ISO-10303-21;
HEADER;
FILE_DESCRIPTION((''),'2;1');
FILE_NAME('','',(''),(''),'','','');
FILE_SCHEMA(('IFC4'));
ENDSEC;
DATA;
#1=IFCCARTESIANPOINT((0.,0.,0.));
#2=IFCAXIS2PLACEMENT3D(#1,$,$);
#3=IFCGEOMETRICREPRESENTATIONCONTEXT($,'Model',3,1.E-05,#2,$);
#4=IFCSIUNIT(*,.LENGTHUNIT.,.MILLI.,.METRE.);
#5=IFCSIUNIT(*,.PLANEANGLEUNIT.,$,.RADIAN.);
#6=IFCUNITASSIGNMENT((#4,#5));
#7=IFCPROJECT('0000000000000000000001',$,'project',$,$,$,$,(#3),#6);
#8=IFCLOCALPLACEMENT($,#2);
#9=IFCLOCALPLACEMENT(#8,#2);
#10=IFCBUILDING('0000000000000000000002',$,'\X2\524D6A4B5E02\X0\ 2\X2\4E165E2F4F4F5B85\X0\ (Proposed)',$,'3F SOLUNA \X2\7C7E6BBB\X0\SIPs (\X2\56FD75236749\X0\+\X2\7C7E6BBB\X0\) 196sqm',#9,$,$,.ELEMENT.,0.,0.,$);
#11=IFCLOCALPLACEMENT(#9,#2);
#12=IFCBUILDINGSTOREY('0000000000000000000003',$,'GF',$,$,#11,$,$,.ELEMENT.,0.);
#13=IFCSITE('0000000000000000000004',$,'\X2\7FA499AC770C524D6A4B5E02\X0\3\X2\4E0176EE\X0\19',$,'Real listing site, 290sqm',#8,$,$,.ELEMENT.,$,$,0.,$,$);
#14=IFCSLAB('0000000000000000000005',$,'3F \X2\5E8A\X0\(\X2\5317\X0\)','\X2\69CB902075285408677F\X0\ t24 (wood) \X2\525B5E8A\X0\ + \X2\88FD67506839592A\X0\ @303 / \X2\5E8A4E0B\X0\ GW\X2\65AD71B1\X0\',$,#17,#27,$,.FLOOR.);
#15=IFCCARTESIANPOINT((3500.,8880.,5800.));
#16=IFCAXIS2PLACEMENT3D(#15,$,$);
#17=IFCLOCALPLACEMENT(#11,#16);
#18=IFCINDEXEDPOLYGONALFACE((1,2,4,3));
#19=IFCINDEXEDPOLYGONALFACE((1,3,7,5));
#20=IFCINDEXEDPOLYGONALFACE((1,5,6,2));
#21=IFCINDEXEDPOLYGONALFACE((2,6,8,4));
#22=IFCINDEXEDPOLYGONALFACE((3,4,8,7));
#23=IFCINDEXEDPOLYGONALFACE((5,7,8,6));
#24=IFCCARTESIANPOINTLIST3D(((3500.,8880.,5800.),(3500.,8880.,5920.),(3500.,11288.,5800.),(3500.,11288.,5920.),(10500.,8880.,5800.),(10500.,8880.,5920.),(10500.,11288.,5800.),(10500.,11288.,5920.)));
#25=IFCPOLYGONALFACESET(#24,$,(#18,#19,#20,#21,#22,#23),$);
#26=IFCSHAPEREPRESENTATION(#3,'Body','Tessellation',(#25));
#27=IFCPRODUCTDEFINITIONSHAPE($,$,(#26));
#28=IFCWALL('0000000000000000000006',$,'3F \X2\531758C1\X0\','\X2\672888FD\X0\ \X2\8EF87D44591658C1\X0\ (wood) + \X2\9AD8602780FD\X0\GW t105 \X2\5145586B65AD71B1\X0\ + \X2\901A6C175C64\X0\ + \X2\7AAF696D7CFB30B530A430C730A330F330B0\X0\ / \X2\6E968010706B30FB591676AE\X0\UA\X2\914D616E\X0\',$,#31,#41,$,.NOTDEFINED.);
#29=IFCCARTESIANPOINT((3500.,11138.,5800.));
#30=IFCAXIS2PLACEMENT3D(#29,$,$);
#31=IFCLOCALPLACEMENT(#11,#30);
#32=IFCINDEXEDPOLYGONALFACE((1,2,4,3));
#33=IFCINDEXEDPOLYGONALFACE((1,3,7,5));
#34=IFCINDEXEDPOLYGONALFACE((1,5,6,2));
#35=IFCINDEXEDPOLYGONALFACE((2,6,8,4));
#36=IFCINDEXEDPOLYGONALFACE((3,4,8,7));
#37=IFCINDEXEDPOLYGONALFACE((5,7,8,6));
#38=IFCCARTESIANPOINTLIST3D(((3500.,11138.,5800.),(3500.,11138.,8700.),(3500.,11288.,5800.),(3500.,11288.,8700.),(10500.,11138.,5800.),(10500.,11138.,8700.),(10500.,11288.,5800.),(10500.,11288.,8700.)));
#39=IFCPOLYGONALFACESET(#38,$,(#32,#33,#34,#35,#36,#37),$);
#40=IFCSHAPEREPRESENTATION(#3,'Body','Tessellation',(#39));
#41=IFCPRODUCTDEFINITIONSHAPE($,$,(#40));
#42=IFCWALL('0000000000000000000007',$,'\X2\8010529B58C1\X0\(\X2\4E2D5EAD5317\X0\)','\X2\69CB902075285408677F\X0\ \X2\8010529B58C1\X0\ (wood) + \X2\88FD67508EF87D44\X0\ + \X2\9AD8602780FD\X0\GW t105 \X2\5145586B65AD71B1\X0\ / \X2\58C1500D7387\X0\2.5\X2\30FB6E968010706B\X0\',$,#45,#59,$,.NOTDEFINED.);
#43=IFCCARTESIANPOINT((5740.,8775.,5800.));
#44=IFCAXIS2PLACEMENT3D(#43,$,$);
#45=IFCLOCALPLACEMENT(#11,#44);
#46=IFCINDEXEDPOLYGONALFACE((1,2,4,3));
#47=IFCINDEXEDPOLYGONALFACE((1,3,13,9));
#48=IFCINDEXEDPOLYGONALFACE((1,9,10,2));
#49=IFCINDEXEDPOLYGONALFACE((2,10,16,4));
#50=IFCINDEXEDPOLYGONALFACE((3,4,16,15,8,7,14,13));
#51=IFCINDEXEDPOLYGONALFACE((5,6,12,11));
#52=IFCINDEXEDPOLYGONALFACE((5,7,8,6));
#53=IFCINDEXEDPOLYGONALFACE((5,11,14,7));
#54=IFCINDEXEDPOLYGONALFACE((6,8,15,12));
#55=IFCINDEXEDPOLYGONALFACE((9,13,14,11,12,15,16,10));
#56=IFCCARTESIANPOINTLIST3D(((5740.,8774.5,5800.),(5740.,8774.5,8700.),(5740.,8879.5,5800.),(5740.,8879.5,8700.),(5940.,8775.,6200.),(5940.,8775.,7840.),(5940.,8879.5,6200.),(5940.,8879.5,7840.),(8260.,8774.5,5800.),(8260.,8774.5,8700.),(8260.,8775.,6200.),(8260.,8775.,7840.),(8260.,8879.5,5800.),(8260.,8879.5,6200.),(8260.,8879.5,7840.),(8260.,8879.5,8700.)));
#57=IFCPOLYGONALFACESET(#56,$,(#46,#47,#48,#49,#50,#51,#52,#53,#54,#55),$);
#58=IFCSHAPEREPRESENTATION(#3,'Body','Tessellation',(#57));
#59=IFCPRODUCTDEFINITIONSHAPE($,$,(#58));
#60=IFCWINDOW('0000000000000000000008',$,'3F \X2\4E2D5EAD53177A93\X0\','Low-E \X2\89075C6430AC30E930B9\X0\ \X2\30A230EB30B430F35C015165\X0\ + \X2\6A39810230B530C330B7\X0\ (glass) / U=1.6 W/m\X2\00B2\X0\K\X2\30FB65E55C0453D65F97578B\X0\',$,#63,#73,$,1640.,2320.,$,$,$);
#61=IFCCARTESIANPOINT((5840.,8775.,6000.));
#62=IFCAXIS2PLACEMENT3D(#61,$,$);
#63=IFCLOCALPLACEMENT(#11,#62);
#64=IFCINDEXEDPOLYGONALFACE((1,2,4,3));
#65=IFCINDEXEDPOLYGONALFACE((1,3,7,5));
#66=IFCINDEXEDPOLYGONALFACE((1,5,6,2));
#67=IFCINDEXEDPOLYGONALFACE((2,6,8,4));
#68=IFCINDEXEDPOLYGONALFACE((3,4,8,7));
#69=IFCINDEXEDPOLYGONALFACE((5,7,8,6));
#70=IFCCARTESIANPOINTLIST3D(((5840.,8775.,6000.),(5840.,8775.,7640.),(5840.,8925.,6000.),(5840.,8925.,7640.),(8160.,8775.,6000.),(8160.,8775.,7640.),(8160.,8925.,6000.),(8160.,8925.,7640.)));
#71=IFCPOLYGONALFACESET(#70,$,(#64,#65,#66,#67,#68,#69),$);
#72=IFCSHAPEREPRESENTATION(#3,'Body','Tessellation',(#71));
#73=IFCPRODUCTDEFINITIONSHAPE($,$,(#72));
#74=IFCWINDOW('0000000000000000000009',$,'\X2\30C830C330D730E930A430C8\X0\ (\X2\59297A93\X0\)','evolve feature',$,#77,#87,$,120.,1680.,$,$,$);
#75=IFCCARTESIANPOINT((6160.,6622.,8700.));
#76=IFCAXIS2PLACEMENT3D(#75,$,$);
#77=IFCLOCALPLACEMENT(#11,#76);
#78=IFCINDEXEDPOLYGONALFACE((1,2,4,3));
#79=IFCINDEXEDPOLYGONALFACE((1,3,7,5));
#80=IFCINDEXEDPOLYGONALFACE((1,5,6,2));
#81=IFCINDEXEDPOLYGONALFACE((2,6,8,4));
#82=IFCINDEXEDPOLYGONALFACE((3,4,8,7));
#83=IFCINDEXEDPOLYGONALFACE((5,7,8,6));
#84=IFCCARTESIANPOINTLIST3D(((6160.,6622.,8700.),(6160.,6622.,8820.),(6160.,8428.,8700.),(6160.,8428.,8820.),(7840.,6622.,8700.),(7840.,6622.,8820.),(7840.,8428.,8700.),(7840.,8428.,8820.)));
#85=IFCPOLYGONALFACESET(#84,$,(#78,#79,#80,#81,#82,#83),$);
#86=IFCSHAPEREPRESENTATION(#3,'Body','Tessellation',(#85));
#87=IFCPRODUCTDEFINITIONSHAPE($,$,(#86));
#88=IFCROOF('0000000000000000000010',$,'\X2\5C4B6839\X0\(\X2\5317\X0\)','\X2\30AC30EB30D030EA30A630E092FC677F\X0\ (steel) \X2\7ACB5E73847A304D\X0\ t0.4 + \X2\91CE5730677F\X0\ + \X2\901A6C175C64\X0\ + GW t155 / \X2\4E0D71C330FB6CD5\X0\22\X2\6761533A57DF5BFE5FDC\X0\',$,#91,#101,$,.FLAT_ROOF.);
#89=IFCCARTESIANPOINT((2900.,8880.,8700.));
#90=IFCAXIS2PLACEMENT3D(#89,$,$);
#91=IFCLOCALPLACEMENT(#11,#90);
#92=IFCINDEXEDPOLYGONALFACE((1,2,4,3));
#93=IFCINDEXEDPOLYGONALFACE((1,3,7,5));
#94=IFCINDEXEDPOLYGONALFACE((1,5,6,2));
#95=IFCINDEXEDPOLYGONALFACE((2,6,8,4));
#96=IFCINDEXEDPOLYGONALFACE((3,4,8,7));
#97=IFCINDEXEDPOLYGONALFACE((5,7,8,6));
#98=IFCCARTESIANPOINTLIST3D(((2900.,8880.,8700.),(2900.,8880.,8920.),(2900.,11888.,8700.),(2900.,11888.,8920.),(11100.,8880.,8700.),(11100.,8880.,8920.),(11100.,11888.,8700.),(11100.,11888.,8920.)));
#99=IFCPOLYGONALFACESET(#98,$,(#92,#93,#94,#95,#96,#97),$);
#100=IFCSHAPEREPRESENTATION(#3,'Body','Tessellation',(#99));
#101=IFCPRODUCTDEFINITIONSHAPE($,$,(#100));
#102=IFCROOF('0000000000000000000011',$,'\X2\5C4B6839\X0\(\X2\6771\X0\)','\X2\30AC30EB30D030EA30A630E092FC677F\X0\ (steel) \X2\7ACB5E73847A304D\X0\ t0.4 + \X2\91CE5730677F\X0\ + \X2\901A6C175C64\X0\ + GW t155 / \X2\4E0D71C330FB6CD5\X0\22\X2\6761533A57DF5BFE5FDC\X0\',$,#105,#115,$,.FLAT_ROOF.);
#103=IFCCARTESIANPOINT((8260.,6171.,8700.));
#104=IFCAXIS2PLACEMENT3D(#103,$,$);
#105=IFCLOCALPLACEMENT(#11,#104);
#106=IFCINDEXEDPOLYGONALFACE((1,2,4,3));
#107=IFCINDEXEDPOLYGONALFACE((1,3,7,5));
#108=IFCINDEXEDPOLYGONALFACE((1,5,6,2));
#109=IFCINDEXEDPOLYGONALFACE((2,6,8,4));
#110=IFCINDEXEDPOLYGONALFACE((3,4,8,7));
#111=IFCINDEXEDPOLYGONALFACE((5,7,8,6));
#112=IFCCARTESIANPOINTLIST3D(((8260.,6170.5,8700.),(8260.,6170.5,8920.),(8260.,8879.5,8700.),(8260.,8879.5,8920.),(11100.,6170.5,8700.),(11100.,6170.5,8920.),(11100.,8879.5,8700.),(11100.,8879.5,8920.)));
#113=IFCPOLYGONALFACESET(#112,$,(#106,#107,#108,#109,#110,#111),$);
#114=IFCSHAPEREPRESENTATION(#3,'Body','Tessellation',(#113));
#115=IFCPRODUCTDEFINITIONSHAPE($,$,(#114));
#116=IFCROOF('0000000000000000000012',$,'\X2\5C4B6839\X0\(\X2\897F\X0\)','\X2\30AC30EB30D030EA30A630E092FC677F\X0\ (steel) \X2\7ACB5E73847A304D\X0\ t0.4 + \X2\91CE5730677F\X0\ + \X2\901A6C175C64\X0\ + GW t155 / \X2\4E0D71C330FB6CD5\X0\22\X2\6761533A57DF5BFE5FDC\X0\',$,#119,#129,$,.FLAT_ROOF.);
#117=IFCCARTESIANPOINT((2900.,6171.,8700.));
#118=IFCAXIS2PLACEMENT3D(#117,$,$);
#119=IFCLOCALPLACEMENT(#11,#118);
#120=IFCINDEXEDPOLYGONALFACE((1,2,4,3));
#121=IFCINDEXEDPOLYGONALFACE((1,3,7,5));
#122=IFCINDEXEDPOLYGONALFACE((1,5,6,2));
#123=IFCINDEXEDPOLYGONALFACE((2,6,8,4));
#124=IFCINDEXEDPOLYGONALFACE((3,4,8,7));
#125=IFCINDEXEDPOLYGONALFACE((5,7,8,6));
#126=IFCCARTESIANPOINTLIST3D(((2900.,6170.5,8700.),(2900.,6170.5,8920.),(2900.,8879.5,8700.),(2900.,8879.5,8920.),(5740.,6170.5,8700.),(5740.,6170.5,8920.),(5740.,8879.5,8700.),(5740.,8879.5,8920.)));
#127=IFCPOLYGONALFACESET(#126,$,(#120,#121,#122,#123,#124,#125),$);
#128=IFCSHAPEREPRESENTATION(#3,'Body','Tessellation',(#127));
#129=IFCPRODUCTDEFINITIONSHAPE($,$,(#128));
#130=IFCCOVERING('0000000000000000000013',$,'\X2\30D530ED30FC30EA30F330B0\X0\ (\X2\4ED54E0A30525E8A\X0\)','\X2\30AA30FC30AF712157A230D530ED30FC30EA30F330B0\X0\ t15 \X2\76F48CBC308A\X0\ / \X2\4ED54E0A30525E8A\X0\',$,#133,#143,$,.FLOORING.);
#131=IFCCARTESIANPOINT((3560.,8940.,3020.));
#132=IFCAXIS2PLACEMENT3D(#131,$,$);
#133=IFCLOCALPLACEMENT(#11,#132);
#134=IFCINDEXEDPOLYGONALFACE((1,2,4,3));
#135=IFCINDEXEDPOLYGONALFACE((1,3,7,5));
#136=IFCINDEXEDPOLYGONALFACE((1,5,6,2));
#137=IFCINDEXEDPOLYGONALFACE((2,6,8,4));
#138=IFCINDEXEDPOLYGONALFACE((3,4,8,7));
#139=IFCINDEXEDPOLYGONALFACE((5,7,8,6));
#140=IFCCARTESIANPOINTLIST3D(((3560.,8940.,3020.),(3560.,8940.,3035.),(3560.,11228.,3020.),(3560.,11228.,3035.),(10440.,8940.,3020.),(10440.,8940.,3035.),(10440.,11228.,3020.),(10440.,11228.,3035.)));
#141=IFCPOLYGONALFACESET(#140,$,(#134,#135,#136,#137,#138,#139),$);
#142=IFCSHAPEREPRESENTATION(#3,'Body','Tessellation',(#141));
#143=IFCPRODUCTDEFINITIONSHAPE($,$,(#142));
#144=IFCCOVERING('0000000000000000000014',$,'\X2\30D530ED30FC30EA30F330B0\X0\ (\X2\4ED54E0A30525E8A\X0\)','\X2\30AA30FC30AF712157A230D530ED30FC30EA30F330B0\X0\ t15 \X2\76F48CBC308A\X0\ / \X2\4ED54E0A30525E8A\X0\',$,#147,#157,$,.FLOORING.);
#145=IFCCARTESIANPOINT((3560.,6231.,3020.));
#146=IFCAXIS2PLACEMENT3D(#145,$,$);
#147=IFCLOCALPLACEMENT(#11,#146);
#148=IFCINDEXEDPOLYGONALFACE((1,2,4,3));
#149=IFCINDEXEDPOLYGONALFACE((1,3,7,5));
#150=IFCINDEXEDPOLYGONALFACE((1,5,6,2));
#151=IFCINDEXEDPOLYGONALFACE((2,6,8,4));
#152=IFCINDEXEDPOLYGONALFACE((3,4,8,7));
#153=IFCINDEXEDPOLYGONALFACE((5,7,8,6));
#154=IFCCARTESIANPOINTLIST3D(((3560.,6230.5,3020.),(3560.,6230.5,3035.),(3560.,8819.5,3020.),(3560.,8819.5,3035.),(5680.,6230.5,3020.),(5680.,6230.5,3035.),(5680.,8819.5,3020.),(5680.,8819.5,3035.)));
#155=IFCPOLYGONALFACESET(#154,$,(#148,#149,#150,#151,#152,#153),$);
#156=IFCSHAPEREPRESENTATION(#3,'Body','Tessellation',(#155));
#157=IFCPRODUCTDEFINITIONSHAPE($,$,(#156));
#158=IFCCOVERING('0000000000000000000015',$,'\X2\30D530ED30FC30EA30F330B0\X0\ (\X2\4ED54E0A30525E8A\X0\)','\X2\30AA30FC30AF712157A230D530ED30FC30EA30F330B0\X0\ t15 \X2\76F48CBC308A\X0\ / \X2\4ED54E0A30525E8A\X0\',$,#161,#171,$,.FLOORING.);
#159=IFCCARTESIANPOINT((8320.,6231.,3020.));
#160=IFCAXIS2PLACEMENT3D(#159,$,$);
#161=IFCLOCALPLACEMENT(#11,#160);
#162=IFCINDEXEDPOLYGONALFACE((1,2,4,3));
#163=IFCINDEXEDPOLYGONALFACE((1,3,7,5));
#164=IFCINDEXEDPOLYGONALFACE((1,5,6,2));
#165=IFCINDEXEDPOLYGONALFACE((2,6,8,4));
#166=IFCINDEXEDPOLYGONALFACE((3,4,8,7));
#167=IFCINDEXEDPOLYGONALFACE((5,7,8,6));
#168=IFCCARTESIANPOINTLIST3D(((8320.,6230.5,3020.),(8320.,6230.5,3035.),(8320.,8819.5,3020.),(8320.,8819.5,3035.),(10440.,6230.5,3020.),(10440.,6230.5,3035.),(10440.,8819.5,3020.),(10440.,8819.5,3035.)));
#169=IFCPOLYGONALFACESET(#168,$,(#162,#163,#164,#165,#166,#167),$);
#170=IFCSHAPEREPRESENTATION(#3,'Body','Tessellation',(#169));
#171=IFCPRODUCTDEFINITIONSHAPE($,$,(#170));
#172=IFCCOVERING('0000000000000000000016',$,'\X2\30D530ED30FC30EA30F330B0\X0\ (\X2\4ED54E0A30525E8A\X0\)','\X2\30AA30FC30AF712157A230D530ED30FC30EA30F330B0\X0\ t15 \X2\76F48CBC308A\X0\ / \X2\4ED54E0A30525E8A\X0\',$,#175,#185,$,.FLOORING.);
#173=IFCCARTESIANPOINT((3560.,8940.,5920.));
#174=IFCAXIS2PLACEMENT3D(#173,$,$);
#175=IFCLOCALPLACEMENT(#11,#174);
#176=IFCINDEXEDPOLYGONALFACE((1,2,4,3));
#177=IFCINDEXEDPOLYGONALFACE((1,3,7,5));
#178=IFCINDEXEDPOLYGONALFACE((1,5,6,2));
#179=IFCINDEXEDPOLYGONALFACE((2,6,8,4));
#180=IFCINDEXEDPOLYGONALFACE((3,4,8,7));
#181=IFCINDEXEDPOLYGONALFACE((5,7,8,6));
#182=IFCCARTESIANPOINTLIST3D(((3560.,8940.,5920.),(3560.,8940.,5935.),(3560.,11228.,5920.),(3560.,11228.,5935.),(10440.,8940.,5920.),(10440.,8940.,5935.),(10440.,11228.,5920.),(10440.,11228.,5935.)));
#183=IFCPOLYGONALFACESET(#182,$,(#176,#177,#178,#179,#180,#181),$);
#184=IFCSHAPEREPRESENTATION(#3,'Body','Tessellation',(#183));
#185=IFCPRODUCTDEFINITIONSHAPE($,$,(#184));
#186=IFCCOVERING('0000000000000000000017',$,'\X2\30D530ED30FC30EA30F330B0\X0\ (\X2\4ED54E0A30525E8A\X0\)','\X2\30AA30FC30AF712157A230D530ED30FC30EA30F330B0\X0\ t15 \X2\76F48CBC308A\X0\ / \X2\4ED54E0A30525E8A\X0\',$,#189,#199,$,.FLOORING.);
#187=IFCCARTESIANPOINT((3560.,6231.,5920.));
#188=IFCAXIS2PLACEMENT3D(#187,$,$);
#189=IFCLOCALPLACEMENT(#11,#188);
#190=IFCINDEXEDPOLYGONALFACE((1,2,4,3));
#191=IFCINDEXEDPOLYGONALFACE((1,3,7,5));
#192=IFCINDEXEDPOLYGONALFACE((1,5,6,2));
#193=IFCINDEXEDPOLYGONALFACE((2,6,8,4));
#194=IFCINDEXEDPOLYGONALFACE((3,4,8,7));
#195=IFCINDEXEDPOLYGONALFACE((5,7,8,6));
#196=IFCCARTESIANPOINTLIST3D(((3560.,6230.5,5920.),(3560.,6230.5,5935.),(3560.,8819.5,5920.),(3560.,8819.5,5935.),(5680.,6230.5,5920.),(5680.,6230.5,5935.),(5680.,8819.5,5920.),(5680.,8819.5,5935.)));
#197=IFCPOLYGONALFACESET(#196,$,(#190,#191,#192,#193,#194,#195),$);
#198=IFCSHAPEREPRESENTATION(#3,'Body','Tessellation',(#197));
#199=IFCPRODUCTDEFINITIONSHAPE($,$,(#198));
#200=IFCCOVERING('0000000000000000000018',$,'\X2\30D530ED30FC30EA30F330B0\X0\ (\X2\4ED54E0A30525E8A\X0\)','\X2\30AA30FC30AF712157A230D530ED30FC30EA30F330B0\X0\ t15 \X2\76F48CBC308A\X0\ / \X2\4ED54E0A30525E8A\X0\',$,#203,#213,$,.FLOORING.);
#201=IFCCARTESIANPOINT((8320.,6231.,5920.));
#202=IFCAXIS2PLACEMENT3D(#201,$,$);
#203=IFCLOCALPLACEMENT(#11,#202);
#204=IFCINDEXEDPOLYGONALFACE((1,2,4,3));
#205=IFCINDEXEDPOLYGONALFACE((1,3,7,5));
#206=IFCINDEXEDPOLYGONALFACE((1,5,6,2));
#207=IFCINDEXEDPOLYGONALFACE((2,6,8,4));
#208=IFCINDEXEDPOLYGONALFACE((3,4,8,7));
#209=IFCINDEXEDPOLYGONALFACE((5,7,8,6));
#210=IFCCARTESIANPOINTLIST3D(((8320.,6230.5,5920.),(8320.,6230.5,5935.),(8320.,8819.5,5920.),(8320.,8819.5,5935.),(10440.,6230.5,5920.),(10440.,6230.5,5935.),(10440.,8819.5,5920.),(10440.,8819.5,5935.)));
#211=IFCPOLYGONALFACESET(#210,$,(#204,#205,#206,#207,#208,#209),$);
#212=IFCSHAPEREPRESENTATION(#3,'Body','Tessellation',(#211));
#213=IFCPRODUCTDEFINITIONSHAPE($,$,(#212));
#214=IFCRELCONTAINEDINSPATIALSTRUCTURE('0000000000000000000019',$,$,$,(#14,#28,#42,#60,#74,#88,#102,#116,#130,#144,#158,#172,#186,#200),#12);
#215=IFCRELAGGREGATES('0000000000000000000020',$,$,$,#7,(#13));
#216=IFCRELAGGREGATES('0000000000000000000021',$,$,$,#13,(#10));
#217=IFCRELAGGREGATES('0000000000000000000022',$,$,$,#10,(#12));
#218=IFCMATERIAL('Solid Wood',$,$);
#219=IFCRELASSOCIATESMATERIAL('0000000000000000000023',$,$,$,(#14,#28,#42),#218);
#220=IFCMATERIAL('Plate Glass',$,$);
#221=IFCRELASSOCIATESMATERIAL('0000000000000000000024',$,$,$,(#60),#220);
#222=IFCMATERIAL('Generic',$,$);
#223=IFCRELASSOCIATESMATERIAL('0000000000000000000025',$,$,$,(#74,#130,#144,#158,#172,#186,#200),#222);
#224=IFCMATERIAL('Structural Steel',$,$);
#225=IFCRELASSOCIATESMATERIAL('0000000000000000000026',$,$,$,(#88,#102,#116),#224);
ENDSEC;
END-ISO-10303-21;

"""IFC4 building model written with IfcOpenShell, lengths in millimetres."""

from ifc_helpers import new_model, si_unit, frame, frame_2d, origin, place, context, project, spatial, rectangle, extrude, material, element, fill, save


model = new_model("IFC4")

# Units and contexts
model_context = context("Model", 3, precision=1e-05, world=origin())
ifc_project = project(units=[si_unit("LENGTHUNIT", "METRE", prefix="MILLI"), si_unit("PLANEANGLEUNIT", "RADIAN")], contexts=[model_context])

# Site, building, storey
site_placement = place(None, origin())
site = spatial("IfcSite", under=ifc_project, at=site_placement, Name="群馬県前橋市3丁目19", ObjectType="Real listing site, 290sqm", CompositionType="ELEMENT", RefElevation=0.0)
building_placement = place(site_placement, origin())
building = spatial("IfcBuilding", under=site, at=building_placement, Name="前橋市 2世帯住宅 (Proposed)", ObjectType="3F SOLUNA 籾殻SIPs (国産杉+籾殻) 196sqm", CompositionType="ELEMENT", ElevationOfRefHeight=0.0, ElevationOfTerrain=0.0)
storey_placement = place(building_placement, origin())
storey = spatial("IfcBuildingStorey", under=building, at=storey_placement, Name="GF", CompositionType="ELEMENT", Elevation=0.0)

# Slab
ifc_material_1 = material(Name="Solid Wood")
slab_placement = place(storey_placement, frame((3500.0, 8880.0, 5800.0)))
element("IfcSlab", 1, at=slab_placement, inside=storey, material=ifc_material_1, Name="3F 床(北)", Description="構造用合板 t24 (wood) 剛床 + 製材根太 @303 / 床下 GW断熱", PredefinedType="FLOOR", context=model_context, shape_type="SweptSolid", body=[
    extrude(rectangle(XDim=7000.0, YDim=2408.0, at=frame_2d((3500.0, 1204.0))), frame((3500.0, 8880.0, 5800.0)), (0.0, 0.0, 1.0), 120.0),
])

# Wall
wall_1_placement = place(storey_placement, frame((3500.0, 11138.0, 5800.0)))
element("IfcWall", 2, at=wall_1_placement, inside=storey, material=ifc_material_1, Name="3F 北壁", Description="木製 軸組外壁 (wood) + 高性能GW t105 充填断熱 + 通気層 + 窯業系サイディング / 準耐火・外皮UA配慮", PredefinedType="NOTDEFINED", context=model_context, shape_type="SweptSolid", body=[
    extrude(rectangle(XDim=7000.0, YDim=150.0, at=frame_2d((3500.0, 75.0))), frame((3500.0, 11138.0, 5800.0)), (0.0, 0.0, 1.0), 2900.0),
])

# Wall, opening, window
wall_2_placement = place(storey_placement, frame((5740.0, 8775.0, 5800.0)))
wall_2 = element("IfcWall", 3, at=wall_2_placement, inside=storey, material=ifc_material_1, Name="耐力壁(中庭北)", Description="構造用合板 耐力壁 (wood) + 製材軸組 + 高性能GW t105 充填断熱 / 壁倍率2.5・準耐火", PredefinedType="NOTDEFINED", context=model_context, shape_type="SweptSolid", body=[
    extrude(rectangle(XDim=2520.0, YDim=105.0, at=frame_2d((1260.0, 52.0))), frame((5740.0, 8775.0, 5800.0)), (0.0, 0.0, 1.0), 2900.0),
])
opening_placement = place(storey_placement, frame((5840.0, 8775.0, 6000.0)))
opening = element("IfcOpeningElement", 4, at=opening_placement, cuts=wall_2, PredefinedType="NOTDEFINED", context=model_context, shape_type="SweptSolid", body=[
    extrude(rectangle(XDim=2320.0, YDim=150.0, at=frame_2d((1160.0, 75.0))), frame((5840.0, 8775.0, 6000.0)), (0.0, 0.0, 1.0), 1640.0),
])
ifc_material_2 = material(Name="Plate Glass")
window_1_placement = place(storey_placement, frame((5840.0, 8775.0, 6000.0)))
window_1 = element("IfcWindow", 5, at=window_1_placement, inside=storey, material=ifc_material_2, Name="3F 中庭北窓", Description="Low-E 複層ガラス アルゴン封入 + 樹脂サッシ (glass) / U=1.6 W/m²K・日射取得型", OverallHeight=1640.0, OverallWidth=2320.0, context=model_context, shape_type="SweptSolid", body=[
    extrude(rectangle(XDim=2320.0, YDim=150.0, at=frame_2d((1160.0, 75.0))), frame((5840.0, 8775.0, 6000.0)), (0.0, 0.0, 1.0), 1640.0),
])
fill(opening, window_1)

# Window
ifc_material_3 = material(Name="Generic")
window_2_placement = place(storey_placement, frame((6160.0, 6622.0, 8700.0)))
element("IfcWindow", 6, at=window_2_placement, inside=storey, material=ifc_material_3, Name="トップライト (天窓)", Description="evolve feature", OverallHeight=120.0, OverallWidth=1680.0, context=model_context, shape_type="SweptSolid", body=[
    extrude(rectangle(XDim=1680.0, YDim=1806.0, at=frame_2d((840.0, 903.0))), frame((6160.0, 6622.0, 8700.0)), (0.0, 0.0, 1.0), 120.0),
])

# Roofs
ifc_material_4 = material(Name="Structural Steel")
roof_1_placement = place(storey_placement, frame((2900.0, 8880.0, 8700.0)))
element("IfcRoof", 7, at=roof_1_placement, inside=storey, material=ifc_material_4, Name="屋根(北)", Description="ガルバリウム鋼板 (steel) 立平葺き t0.4 + 野地板 + 通気層 + GW t155 / 不燃・法22条区域対応", PredefinedType="FLAT_ROOF", context=model_context, shape_type="SweptSolid", body=[
    extrude(rectangle(XDim=8200.0, YDim=3008.0, at=frame_2d((4100.0, 1504.0))), frame((2900.0, 8880.0, 8700.0)), (0.0, 0.0, 1.0), 220.0),
])
roof_2_placement = place(storey_placement, frame((8260.0, 6171.0, 8700.0)))
element("IfcRoof", 8, at=roof_2_placement, inside=storey, material=ifc_material_4, Name="屋根(東)", Description="ガルバリウム鋼板 (steel) 立平葺き t0.4 + 野地板 + 通気層 + GW t155 / 不燃・法22条区域対応", PredefinedType="FLAT_ROOF", context=model_context, shape_type="SweptSolid", body=[
    extrude(rectangle(XDim=2840.0, YDim=2709.0, at=frame_2d((1420.0, 1354.0))), frame((8260.0, 6171.0, 8700.0)), (0.0, 0.0, 1.0), 220.0),
])
roof_3_placement = place(storey_placement, frame((2900.0, 6171.0, 8700.0)))
element("IfcRoof", 9, at=roof_3_placement, inside=storey, material=ifc_material_4, Name="屋根(西)", Description="ガルバリウム鋼板 (steel) 立平葺き t0.4 + 野地板 + 通気層 + GW t155 / 不燃・法22条区域対応", PredefinedType="FLAT_ROOF", context=model_context, shape_type="SweptSolid", body=[
    extrude(rectangle(XDim=2840.0, YDim=2709.0, at=frame_2d((1420.0, 1354.0))), frame((2900.0, 6171.0, 8700.0)), (0.0, 0.0, 1.0), 220.0),
])

# Coverings
covering_1_placement = place(storey_placement, frame((3560.0, 8940.0, 3020.0)))
element("IfcCovering", 10, at=covering_1_placement, inside=storey, material=ifc_material_3, Name="フローリング (仕上げ床)", Description="オーク無垢フローリング t15 直貼り / 仕上げ床", PredefinedType="FLOORING", context=model_context, shape_type="SweptSolid", body=[
    extrude(rectangle(XDim=6880.0, YDim=2288.0, at=frame_2d((3440.0, 1144.0))), frame((3560.0, 8940.0, 3020.0)), (0.0, 0.0, 1.0), 15.0),
])
covering_2_placement = place(storey_placement, frame((3560.0, 6231.0, 3020.0)))
element("IfcCovering", 11, at=covering_2_placement, inside=storey, material=ifc_material_3, Name="フローリング (仕上げ床)", Description="オーク無垢フローリング t15 直貼り / 仕上げ床", PredefinedType="FLOORING", context=model_context, shape_type="SweptSolid", body=[
    extrude(rectangle(XDim=2120.0, YDim=2589.0, at=frame_2d((1060.0, 1294.0))), frame((3560.0, 6231.0, 3020.0)), (0.0, 0.0, 1.0), 15.0),
])
covering_3_placement = place(storey_placement, frame((8320.0, 6231.0, 3020.0)))
element("IfcCovering", 12, at=covering_3_placement, inside=storey, material=ifc_material_3, Name="フローリング (仕上げ床)", Description="オーク無垢フローリング t15 直貼り / 仕上げ床", PredefinedType="FLOORING", context=model_context, shape_type="SweptSolid", body=[
    extrude(rectangle(XDim=2120.0, YDim=2589.0, at=frame_2d((1060.0, 1294.0))), frame((8320.0, 6231.0, 3020.0)), (0.0, 0.0, 1.0), 15.0),
])
covering_4_placement = place(storey_placement, frame((3560.0, 8940.0, 5920.0)))
element("IfcCovering", 13, at=covering_4_placement, inside=storey, material=ifc_material_3, Name="フローリング (仕上げ床)", Description="オーク無垢フローリング t15 直貼り / 仕上げ床", PredefinedType="FLOORING", context=model_context, shape_type="SweptSolid", body=[
    extrude(rectangle(XDim=6880.0, YDim=2288.0, at=frame_2d((3440.0, 1144.0))), frame((3560.0, 8940.0, 5920.0)), (0.0, 0.0, 1.0), 15.0),
])
covering_5_placement = place(storey_placement, frame((3560.0, 6231.0, 5920.0)))
element("IfcCovering", 14, at=covering_5_placement, inside=storey, material=ifc_material_3, Name="フローリング (仕上げ床)", Description="オーク無垢フローリング t15 直貼り / 仕上げ床", PredefinedType="FLOORING", context=model_context, shape_type="SweptSolid", body=[
    extrude(rectangle(XDim=2120.0, YDim=2589.0, at=frame_2d((1060.0, 1294.0))), frame((3560.0, 6231.0, 5920.0)), (0.0, 0.0, 1.0), 15.0),
])
covering_6_placement = place(storey_placement, frame((8320.0, 6231.0, 5920.0)))
element("IfcCovering", 15, at=covering_6_placement, inside=storey, material=ifc_material_3, Name="フローリング (仕上げ床)", Description="オーク無垢フローリング t15 直貼り / 仕上げ床", PredefinedType="FLOORING", context=model_context, shape_type="SweptSolid", body=[
    extrude(rectangle(XDim=2120.0, YDim=2589.0, at=frame_2d((1060.0, 1294.0))), frame((8320.0, 6231.0, 5920.0)), (0.0, 0.0, 1.0), 15.0),
])

save(model, "model.ifc")
